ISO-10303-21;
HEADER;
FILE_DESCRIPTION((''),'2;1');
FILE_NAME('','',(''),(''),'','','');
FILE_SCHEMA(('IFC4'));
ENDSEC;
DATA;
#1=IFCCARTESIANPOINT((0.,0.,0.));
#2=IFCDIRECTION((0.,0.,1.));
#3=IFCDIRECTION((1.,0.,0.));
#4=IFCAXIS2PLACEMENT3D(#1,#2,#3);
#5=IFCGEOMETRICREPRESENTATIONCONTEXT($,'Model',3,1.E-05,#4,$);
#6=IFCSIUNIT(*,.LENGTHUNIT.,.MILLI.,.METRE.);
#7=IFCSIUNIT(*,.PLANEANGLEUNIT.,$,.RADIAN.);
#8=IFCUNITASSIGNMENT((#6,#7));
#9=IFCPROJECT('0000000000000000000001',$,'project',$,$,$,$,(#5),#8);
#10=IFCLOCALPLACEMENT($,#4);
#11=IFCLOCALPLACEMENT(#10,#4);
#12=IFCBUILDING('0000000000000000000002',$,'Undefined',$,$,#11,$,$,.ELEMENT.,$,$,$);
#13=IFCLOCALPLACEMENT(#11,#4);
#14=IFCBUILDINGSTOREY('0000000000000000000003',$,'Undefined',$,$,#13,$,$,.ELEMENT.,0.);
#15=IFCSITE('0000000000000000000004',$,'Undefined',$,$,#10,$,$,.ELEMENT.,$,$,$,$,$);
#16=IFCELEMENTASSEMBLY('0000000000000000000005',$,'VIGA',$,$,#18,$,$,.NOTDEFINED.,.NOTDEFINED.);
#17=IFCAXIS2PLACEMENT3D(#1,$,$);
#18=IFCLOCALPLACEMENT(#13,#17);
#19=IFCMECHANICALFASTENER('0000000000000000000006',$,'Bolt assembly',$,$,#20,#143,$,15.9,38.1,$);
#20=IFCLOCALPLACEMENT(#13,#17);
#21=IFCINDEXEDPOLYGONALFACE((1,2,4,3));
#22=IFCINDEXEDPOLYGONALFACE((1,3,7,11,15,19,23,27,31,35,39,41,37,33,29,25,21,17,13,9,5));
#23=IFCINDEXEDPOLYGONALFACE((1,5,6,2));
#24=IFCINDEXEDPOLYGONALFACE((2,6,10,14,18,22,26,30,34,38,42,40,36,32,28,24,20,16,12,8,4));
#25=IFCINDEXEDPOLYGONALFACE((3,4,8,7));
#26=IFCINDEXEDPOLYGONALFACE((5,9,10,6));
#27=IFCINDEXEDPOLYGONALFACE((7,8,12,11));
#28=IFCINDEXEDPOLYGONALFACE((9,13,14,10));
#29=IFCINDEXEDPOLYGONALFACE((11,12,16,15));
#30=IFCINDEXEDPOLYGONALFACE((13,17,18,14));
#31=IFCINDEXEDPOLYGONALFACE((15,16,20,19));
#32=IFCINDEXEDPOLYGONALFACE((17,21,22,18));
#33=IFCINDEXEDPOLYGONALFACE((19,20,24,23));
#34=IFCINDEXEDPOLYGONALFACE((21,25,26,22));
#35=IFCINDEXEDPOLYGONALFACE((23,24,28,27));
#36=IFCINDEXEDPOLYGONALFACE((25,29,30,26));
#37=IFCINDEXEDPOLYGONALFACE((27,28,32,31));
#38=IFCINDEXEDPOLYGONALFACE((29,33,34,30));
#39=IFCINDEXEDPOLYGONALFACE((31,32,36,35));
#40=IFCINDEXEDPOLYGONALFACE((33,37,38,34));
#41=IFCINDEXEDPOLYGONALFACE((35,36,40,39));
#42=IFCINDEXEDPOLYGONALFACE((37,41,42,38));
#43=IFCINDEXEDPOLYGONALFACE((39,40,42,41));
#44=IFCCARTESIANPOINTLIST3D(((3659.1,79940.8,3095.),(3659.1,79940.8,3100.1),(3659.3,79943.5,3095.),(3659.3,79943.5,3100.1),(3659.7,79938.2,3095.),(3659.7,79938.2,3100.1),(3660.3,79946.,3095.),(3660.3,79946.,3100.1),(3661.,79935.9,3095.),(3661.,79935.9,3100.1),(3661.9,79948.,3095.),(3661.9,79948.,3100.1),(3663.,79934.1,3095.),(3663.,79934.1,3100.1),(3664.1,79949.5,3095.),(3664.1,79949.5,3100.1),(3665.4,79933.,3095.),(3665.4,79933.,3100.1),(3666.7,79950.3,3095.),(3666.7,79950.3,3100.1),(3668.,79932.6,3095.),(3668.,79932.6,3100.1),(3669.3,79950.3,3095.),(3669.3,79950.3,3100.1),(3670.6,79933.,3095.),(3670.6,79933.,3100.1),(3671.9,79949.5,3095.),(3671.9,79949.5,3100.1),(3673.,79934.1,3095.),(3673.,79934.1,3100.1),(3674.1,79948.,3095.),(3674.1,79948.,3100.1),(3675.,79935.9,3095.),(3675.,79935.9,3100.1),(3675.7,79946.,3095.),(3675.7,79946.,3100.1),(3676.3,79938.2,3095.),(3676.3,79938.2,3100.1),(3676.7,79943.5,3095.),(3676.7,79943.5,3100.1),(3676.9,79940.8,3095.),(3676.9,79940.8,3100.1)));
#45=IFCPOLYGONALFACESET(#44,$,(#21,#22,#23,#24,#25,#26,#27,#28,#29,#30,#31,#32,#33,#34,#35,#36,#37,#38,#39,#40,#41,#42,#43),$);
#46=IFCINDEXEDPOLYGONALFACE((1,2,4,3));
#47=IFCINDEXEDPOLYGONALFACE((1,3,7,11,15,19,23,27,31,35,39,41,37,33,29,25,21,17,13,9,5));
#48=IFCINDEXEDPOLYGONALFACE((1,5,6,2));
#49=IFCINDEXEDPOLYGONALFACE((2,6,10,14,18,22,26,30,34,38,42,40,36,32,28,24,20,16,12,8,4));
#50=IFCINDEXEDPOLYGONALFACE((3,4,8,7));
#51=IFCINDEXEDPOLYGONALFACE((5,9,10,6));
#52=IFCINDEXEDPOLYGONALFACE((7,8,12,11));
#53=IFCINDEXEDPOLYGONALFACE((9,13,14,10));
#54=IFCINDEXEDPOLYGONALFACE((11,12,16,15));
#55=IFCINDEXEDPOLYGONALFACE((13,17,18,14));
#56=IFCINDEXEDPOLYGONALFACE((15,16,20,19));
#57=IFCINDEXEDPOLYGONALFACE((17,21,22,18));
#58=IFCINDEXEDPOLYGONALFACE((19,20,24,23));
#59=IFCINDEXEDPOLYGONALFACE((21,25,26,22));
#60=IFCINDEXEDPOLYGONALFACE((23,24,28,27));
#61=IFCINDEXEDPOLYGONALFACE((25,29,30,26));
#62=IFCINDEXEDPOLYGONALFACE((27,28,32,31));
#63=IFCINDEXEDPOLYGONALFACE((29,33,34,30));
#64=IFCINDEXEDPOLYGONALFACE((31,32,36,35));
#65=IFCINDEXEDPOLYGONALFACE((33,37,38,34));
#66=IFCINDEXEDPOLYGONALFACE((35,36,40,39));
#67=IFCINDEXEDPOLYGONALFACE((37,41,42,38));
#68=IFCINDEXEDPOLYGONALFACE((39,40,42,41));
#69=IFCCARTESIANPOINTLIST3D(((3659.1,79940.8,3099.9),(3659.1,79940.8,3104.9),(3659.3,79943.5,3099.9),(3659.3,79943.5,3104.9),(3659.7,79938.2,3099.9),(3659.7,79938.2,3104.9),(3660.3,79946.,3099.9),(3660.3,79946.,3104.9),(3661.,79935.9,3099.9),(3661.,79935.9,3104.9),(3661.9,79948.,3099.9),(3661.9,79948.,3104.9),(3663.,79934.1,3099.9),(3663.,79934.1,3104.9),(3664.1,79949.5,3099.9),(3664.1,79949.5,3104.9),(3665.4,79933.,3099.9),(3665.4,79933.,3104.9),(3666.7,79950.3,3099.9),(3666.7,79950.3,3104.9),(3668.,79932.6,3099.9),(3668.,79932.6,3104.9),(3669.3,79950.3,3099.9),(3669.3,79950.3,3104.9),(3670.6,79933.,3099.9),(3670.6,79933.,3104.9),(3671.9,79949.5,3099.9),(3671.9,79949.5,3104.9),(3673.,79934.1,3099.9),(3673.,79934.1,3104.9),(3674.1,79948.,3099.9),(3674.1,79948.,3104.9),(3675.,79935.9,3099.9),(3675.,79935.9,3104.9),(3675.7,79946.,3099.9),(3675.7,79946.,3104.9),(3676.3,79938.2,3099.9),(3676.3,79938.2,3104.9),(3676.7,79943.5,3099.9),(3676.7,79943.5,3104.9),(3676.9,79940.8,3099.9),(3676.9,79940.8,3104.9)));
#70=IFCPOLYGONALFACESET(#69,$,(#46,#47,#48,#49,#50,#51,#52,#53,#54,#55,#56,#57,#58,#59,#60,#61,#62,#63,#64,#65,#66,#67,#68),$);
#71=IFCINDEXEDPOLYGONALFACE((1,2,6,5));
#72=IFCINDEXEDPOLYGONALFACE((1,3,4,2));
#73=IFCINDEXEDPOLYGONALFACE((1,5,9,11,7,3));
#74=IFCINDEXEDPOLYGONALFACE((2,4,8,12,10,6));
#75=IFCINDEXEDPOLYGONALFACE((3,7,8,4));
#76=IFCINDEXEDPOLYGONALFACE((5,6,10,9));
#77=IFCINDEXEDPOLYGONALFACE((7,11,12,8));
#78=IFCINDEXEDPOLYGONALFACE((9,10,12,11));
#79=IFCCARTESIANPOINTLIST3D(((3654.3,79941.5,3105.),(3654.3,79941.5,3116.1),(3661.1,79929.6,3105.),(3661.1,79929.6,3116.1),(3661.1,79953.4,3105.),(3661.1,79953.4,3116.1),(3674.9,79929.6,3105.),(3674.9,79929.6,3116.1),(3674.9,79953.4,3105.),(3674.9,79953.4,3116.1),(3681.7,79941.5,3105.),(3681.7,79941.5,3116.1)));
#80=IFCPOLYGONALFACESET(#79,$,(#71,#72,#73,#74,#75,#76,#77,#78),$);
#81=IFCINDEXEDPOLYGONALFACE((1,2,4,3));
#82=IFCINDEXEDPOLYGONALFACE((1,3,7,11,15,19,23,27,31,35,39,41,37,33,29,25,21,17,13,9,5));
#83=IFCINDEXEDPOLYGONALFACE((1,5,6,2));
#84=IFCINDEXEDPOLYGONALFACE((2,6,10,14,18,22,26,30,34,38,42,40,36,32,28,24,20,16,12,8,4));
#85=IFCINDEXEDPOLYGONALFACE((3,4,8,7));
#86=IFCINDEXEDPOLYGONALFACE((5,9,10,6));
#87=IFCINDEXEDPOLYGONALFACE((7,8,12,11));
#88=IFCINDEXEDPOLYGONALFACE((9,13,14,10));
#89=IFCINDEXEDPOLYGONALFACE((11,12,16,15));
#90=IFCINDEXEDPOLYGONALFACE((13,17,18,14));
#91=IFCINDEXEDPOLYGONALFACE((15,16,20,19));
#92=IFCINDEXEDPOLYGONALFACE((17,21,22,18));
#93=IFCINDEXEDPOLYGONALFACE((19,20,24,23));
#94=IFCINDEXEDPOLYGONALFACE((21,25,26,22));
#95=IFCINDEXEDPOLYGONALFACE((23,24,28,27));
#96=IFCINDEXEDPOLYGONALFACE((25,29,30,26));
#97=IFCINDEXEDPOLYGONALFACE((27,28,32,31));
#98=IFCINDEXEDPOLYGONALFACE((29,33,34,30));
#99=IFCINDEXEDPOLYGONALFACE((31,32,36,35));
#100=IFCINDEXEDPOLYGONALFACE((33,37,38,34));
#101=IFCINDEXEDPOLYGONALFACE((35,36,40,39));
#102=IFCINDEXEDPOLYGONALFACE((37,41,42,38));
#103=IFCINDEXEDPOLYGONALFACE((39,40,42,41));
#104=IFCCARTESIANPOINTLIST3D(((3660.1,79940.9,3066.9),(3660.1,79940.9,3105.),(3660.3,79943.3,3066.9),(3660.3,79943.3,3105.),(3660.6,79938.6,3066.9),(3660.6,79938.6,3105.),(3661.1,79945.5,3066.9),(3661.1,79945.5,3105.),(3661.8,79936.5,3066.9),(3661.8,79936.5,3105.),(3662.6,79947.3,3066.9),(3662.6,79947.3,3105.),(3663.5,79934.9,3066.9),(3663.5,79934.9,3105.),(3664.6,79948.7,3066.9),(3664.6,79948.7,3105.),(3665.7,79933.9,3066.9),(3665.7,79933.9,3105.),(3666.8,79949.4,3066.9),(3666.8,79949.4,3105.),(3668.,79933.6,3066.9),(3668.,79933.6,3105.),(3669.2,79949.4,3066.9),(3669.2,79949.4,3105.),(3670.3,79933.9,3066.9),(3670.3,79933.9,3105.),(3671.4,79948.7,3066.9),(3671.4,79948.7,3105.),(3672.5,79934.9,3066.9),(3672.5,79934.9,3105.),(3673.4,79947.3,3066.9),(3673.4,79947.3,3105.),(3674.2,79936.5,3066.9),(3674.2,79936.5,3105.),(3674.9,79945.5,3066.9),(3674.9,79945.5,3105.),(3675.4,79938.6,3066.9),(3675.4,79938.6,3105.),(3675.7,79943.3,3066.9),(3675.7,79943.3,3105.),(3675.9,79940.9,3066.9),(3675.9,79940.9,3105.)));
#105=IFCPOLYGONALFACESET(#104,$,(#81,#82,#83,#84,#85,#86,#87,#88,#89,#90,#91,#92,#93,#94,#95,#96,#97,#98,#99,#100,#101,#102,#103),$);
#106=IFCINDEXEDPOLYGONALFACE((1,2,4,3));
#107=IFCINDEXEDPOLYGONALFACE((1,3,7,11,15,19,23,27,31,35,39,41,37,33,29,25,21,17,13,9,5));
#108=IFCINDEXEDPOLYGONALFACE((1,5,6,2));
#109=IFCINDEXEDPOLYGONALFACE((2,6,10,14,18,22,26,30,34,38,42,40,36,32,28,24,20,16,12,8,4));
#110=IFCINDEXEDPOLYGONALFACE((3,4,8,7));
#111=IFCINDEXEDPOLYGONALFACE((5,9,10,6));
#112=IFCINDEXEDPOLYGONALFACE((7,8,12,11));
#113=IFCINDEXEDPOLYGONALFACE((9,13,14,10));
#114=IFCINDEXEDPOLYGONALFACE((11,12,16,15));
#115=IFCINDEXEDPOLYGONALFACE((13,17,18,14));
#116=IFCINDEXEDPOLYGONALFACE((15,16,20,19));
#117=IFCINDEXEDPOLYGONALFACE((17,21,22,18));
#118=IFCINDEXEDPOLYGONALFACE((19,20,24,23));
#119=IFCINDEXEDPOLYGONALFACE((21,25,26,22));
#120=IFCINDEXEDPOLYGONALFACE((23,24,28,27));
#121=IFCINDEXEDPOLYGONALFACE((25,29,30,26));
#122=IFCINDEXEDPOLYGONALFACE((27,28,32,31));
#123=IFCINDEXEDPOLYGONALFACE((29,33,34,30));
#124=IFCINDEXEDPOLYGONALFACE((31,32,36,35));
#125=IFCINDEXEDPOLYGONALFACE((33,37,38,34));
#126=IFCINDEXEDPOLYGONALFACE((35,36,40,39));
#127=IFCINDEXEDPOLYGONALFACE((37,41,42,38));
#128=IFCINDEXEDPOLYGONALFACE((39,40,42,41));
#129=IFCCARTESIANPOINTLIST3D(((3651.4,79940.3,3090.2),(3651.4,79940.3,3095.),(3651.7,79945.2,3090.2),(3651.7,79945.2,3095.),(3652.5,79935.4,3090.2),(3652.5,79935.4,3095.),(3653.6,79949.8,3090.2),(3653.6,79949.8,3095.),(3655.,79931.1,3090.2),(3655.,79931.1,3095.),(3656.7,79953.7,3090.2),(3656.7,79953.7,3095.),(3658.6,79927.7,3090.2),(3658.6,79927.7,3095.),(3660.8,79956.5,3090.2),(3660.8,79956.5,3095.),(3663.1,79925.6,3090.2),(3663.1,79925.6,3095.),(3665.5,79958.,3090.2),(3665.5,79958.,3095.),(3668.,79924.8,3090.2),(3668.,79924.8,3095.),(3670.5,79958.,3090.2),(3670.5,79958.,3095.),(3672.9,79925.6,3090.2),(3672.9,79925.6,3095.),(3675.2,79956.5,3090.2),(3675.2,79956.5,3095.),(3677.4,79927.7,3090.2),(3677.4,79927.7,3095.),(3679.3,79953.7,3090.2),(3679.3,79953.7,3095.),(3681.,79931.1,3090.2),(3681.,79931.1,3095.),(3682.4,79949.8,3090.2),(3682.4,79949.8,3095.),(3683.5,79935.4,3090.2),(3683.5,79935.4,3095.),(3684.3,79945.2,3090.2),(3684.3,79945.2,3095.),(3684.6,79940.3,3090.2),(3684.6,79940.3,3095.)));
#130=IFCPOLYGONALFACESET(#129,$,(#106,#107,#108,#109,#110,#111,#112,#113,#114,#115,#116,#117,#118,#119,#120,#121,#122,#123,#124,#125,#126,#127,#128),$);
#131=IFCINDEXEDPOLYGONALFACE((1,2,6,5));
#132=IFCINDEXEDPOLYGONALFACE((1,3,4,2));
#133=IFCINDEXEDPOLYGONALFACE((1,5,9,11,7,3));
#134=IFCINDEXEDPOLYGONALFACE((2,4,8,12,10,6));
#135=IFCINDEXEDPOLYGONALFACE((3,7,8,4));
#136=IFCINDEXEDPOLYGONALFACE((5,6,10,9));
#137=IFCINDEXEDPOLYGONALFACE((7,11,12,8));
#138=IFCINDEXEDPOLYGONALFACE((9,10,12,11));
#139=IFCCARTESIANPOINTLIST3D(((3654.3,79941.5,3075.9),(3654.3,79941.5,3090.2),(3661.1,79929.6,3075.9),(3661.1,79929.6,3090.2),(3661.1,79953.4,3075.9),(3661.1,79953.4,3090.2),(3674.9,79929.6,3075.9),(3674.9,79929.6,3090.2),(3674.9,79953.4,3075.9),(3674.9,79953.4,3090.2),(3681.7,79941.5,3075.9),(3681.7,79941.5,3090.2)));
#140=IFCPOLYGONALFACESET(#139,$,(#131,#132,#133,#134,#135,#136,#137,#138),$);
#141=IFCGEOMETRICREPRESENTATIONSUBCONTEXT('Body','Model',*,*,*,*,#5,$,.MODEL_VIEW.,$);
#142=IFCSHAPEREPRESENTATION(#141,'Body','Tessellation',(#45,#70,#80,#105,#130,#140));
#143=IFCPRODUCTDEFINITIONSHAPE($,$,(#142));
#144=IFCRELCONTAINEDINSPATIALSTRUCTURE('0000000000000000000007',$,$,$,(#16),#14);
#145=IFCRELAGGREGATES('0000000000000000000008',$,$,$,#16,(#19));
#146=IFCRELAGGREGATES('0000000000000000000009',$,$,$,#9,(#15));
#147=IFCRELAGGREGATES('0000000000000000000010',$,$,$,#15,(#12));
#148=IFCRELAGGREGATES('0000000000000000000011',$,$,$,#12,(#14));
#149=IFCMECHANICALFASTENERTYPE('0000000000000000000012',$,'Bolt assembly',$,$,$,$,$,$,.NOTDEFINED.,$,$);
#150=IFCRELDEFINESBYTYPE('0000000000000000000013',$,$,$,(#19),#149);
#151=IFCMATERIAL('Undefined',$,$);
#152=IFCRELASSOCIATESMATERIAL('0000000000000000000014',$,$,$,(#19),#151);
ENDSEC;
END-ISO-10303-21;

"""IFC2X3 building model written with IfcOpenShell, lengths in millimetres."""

from ifc_helpers import new_model, si_unit, frame, origin_with_axes, origin_2d_with_axis, place, context, subcontext, project, spatial, polyline, circle, outline, extrude, source, transform, mapped, material, type_object, element, aggregate, save


model = new_model("IFC2X3")

# Units and contexts
model_context = context("Model", 3, precision=1e-05, world=origin_with_axes())
body_context = subcontext(model_context, "Body", "Model", "MODEL_VIEW")
ifc_project = project(units=[si_unit("LENGTHUNIT", "METRE", prefix="MILLI"), si_unit("PLANEANGLEUNIT", "RADIAN")], contexts=[model_context])

# Site, building, storey
site_placement = place(None, origin_with_axes())
site = spatial("IfcSite", under=ifc_project, at=site_placement, Name="Undefined", CompositionType="ELEMENT")
building_placement = place(site_placement, origin_with_axes())
building = spatial("IfcBuilding", under=site, at=building_placement, Name="Undefined", CompositionType="ELEMENT")
storey_placement = place(building_placement, origin_with_axes())
storey = spatial("IfcBuildingStorey", under=building, at=storey_placement, Name="Undefined", CompositionType="ELEMENT", Elevation=0.0)

# Element assembly
assembly_1_placement = place(storey_placement, origin_with_axes())
assembly_1 = element("IfcElementAssembly", 1, at=assembly_1_placement, inside=storey, Name="VIGA", AssemblyPlace="NOTDEFINED", PredefinedType="NOTDEFINED")

# Mechanical fastener
ifc_material_1 = material(Name="Undefined")
mechanical_fastener_type = type_object("IfcMechanicalFastenerType", Name="Bolt assembly")
shared_shape_1 = source(origin_with_axes(), body_context, "Body", "SweptSolid", [
    extrude(circle(Radius=8.9, at=origin_2d_with_axis()), frame((0.0, -0.1, 0.0), z_axis=(0.0, 1.0, 0.0), x_axis=(1.0, 0.0, 0.0)), (0.0, 0.0, 1.0), 5.1),
    extrude(circle(Radius=8.9, at=origin_2d_with_axis()), frame((0.0, -4.9, 0.0), z_axis=(0.0, 1.0, 0.0), x_axis=(1.0, 0.0, 0.0)), (0.0, 0.0, 1.0), 5.0),
    extrude(outline(polyline([(11.9, -6.9), (11.9, 6.9), (0.0, 13.7), (-11.9, 6.9), (-11.9, -6.9), (0.0, -13.7), (11.9, -6.9)])), frame((0.0, -16.1, 0.0), z_axis=(0.0, 1.0, 0.0), x_axis=(1.0, 0.0, 0.0)), (0.0, 0.0, 1.0), 11.1),
    extrude(circle(Radius=7.9, at=origin_2d_with_axis()), frame((0.0, -5.0, 0.0), z_axis=(0.0, 1.0, 0.0), x_axis=(1.0, 0.0, 0.0)), (0.0, 0.0, 1.0), 38.1),
    extrude(circle(Radius=16.7, at=origin_2d_with_axis()), frame((0.0, 5.0, 0.0), z_axis=(0.0, 1.0, 0.0), x_axis=(1.0, 0.0, 0.0)), (0.0, 0.0, 1.0), 4.8),
    extrude(outline(polyline([(11.9, -6.9), (11.9, 6.9), (0.0, 13.7), (-11.9, 6.9), (-11.9, -6.9), (0.0, -13.7), (11.9, -6.9)])), frame((0.0, 9.8, 0.0), z_axis=(0.0, 1.0, 0.0), x_axis=(1.0, 0.0, 0.0)), (0.0, 0.0, 1.0), 14.3),
])
mechanical_fastener_1_placement = place(assembly_1_placement, frame((3668.0, 79941.5, 3100.0), z_axis=(1.0, 0.000006, 0.0), x_axis=(0.000006, -1.0, 0.0)))
mechanical_fastener_1 = element("IfcMechanicalFastener", 2, at=mechanical_fastener_1_placement, type_object=mechanical_fastener_type, material=ifc_material_1, Name="Bolt assembly", NominalDiameter=15.9, NominalLength=38.1, context=body_context, shape_type="MappedRepresentation", body=[
    mapped(shared_shape_1, transform((0.0, 0.0, 0.0))),
])
aggregate(assembly_1, [mechanical_fastener_1])

save(model, "model.ifc")
